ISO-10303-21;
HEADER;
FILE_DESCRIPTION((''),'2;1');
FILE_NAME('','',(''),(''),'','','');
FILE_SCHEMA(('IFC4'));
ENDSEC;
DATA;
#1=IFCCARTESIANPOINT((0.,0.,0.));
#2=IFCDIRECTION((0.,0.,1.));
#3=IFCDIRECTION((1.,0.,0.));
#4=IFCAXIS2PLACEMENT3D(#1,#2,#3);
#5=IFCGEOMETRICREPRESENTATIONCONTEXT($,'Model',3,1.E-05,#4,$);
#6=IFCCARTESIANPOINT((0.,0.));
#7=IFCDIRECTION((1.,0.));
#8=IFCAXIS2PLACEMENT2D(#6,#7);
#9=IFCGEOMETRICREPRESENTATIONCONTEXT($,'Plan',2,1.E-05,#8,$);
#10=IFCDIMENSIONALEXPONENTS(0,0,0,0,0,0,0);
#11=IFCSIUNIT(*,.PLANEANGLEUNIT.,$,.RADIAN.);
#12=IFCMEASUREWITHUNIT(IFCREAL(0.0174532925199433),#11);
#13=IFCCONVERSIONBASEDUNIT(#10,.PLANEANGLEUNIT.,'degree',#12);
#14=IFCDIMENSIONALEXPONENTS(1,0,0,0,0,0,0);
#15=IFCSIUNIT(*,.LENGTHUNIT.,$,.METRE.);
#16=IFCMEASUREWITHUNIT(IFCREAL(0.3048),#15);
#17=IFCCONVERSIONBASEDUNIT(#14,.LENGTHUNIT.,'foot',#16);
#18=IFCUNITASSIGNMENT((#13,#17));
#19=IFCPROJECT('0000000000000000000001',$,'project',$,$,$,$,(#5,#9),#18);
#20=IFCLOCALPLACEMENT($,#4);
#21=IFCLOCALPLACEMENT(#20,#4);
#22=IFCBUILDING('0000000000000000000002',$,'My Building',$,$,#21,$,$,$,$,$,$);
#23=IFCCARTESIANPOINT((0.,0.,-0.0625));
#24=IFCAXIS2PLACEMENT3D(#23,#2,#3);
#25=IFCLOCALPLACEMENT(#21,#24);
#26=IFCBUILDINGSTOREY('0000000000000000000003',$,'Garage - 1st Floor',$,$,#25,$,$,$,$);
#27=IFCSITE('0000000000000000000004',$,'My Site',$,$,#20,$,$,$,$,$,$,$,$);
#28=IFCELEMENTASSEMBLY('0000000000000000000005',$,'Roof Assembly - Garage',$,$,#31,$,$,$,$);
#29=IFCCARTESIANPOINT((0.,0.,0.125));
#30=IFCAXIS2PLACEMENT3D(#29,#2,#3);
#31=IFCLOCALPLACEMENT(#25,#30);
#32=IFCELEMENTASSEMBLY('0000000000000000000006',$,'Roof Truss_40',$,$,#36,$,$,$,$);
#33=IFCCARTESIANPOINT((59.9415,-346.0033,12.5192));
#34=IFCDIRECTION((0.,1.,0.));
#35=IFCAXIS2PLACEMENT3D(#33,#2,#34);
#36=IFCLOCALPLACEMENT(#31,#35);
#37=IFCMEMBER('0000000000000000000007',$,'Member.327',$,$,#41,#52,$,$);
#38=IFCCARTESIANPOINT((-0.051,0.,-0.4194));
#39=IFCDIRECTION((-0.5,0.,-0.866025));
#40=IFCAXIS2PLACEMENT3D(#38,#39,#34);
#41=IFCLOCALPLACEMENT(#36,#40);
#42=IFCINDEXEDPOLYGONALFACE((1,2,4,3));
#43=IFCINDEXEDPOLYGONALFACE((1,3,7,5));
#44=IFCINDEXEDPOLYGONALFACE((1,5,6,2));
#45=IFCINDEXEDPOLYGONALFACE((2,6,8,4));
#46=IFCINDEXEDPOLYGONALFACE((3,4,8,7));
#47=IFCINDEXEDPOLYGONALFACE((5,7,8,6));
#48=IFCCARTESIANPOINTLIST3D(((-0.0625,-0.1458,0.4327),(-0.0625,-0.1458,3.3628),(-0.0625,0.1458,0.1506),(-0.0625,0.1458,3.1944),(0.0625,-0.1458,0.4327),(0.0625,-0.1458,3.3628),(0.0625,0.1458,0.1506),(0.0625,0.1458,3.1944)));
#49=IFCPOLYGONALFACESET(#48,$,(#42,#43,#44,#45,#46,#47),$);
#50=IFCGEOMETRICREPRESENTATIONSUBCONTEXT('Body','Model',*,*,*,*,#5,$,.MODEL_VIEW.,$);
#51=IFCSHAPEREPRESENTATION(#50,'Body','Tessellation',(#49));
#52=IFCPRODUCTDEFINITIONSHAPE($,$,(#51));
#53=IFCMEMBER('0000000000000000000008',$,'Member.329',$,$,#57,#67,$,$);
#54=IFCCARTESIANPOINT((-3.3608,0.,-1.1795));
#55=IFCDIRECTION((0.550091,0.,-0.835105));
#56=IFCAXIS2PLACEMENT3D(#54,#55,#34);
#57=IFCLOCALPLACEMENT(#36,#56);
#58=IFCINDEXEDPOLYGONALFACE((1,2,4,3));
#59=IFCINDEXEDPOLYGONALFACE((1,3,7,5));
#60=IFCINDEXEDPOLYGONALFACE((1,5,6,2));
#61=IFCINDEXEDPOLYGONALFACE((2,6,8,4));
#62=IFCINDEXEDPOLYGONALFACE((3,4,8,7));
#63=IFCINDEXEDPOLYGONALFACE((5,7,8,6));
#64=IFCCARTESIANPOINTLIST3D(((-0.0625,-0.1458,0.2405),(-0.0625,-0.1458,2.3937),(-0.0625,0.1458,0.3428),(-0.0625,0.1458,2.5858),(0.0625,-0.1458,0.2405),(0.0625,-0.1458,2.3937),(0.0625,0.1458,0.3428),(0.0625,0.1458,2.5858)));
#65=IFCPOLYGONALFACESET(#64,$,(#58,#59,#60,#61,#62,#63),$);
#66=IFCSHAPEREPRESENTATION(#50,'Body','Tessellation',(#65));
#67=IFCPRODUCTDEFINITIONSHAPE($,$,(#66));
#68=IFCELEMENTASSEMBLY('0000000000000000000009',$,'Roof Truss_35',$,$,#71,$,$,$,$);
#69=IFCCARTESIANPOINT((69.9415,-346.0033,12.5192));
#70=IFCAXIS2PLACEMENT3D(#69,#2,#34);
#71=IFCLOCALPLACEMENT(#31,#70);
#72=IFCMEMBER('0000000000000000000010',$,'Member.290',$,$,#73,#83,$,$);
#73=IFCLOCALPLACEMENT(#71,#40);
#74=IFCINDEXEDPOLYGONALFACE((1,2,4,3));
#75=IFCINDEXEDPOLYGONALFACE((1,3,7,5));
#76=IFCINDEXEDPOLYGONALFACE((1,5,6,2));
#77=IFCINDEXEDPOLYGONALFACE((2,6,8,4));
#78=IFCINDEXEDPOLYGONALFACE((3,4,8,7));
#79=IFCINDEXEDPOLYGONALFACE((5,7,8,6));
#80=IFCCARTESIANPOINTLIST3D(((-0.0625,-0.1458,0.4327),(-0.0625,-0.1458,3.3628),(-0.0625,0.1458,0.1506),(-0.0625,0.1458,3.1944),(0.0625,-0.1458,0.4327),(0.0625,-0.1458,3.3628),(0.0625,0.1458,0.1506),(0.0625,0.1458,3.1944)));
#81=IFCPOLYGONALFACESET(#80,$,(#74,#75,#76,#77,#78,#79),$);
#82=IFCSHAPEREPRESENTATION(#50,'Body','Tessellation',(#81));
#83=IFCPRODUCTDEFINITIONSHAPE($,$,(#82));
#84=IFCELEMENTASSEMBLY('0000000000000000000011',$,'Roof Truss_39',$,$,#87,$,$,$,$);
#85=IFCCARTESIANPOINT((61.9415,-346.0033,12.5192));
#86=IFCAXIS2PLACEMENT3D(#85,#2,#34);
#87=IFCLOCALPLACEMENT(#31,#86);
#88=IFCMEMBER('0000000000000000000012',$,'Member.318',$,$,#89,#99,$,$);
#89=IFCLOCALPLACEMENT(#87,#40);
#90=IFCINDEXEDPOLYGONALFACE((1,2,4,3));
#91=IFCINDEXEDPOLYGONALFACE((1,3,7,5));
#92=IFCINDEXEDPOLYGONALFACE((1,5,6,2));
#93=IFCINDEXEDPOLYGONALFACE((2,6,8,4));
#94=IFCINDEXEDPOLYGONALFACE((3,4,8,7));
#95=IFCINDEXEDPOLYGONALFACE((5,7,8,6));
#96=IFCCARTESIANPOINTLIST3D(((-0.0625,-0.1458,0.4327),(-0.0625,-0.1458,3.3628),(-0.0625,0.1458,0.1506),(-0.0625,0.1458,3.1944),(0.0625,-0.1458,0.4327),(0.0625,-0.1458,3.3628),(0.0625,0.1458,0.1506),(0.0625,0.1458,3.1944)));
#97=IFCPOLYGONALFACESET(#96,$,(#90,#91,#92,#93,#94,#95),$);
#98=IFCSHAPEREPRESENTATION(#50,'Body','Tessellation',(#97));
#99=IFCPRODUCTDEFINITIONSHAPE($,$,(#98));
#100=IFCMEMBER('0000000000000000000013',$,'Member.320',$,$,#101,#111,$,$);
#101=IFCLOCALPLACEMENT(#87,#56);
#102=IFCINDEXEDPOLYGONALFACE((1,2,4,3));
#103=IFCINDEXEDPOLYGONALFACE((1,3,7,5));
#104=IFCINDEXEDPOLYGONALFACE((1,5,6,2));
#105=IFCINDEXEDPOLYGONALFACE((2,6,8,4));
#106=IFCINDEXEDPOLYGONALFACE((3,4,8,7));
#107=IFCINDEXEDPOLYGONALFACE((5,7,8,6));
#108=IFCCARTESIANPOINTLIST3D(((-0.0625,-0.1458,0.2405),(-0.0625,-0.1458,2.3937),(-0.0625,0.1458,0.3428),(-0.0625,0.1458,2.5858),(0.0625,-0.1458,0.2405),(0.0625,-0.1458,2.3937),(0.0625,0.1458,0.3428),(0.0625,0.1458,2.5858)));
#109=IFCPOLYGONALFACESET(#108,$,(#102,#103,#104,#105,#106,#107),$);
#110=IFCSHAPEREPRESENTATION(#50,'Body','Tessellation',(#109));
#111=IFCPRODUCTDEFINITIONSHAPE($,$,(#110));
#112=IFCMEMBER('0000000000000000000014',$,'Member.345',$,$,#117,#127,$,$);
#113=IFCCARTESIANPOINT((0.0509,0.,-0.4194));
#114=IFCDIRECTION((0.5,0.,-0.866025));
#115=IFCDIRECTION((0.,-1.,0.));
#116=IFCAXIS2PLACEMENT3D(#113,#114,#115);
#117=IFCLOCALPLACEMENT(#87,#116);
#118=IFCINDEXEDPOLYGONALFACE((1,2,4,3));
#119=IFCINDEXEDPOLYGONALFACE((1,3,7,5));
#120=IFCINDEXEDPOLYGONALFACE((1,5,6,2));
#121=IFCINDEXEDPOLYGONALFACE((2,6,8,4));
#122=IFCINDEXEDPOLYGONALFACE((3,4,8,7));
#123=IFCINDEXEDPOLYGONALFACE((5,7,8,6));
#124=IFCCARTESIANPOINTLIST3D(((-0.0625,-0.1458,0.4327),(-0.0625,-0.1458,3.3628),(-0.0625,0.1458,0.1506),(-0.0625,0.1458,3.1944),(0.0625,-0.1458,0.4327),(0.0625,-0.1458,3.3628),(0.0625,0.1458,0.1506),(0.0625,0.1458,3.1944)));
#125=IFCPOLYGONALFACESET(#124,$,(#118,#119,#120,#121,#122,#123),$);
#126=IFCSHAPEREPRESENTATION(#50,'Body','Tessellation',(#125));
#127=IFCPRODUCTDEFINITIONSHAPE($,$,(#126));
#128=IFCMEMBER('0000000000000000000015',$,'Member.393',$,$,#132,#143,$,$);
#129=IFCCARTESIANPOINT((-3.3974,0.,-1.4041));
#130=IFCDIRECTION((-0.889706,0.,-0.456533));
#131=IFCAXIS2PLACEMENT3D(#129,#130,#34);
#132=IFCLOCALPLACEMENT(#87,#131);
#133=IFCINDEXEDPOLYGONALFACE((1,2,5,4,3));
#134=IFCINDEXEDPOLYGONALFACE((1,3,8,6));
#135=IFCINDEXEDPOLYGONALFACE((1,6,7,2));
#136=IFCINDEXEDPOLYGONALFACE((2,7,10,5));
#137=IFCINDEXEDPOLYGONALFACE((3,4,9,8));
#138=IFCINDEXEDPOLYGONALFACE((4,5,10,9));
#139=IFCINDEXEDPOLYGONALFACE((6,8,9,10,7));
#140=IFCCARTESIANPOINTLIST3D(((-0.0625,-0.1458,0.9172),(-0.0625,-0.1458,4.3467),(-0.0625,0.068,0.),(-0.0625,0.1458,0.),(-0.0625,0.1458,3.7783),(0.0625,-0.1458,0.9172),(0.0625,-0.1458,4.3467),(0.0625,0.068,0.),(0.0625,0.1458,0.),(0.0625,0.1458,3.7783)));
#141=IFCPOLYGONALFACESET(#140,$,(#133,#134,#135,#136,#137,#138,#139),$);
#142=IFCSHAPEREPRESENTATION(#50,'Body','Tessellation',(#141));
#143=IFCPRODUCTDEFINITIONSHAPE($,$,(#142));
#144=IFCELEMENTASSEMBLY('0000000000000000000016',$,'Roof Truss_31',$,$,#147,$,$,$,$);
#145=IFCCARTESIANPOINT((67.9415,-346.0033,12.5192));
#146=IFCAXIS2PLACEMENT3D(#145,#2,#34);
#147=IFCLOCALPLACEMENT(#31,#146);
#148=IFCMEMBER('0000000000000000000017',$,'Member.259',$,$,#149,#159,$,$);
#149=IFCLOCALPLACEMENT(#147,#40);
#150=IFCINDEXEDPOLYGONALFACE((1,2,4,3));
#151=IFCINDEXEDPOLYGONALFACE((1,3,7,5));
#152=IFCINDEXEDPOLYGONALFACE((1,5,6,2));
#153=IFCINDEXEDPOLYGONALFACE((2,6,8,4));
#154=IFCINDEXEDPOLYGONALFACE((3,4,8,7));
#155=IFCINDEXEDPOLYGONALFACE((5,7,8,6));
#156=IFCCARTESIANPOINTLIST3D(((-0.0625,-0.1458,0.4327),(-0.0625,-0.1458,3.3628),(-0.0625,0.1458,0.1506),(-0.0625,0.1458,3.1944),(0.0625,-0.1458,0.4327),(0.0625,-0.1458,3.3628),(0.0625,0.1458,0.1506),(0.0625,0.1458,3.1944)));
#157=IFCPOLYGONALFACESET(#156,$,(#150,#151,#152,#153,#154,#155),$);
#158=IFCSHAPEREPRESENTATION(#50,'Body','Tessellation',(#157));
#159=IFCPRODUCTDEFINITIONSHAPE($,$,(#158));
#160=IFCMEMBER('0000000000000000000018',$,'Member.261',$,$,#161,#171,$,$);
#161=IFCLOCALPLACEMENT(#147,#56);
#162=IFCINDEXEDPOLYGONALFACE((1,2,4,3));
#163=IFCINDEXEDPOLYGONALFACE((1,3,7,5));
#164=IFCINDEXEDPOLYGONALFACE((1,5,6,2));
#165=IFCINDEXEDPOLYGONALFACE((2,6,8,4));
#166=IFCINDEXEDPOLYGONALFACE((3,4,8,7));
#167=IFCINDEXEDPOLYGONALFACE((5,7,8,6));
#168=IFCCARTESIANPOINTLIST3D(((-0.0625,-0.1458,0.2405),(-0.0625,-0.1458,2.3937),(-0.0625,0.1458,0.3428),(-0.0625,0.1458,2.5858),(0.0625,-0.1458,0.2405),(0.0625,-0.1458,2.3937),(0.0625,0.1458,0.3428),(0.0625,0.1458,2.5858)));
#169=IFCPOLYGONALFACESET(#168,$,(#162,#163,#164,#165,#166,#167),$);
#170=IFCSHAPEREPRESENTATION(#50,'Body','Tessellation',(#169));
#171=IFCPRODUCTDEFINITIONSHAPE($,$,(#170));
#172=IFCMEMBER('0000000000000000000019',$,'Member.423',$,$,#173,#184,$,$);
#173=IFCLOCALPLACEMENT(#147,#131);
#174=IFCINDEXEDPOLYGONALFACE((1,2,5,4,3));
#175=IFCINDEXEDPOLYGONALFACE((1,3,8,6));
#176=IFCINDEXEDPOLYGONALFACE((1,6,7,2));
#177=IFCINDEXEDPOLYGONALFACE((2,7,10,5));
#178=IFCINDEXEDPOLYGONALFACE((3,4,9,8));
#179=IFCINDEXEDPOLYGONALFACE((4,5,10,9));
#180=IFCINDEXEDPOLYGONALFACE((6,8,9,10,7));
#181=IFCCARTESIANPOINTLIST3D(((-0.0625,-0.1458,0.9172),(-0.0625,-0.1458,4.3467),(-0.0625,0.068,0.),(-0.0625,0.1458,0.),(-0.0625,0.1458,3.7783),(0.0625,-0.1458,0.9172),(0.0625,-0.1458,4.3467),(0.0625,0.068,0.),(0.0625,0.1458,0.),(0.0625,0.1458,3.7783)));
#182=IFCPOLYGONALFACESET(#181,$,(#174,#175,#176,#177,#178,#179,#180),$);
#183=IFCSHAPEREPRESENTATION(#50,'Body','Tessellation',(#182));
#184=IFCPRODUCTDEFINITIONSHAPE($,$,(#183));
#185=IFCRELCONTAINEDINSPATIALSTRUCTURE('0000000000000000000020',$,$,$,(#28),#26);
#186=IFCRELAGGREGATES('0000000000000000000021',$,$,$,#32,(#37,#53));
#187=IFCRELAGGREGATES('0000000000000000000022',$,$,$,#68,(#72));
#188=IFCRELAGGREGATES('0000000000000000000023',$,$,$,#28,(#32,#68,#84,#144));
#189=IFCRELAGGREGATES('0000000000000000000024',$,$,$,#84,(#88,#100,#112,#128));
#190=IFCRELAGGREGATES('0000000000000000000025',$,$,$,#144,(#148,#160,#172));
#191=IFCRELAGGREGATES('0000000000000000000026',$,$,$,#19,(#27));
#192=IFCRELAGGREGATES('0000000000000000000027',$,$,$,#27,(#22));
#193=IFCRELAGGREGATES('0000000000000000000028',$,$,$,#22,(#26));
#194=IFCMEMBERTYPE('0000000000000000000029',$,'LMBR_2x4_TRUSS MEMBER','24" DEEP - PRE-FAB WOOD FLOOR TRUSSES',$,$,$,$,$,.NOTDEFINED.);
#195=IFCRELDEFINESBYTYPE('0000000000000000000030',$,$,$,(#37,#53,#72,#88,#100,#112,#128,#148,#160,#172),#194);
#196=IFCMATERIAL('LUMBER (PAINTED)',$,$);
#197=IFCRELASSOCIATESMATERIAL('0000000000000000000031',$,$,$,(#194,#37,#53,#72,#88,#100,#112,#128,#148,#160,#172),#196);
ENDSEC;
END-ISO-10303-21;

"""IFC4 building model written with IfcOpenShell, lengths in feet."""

from ifc_helpers import new_model, entity, si_unit, converted_unit, frame, origin_with_axes, origin_2d_with_axis, place, context, subcontext, project, spatial, indexed_curve, outline, extrude, clip, halfspace, material, material_profile, profile_set, profile_usage, type_object, element, aggregate, save


model = new_model("IFC4")

# Units and contexts
model_context = context("Model", 3, precision=1e-05, world=origin_with_axes())
plan_context = context("Plan", 2, precision=1e-05, world=origin_2d_with_axis())
body_context = subcontext(model_context, "Body", "Model", "MODEL_VIEW")
ifc_project = project(units=[converted_unit("PLANEANGLEUNIT", "degree", entity("IfcReal", 0.0174532925199433), si_unit("PLANEANGLEUNIT", "RADIAN"), dimensions=[0, 0, 0, 0, 0, 0, 0]), converted_unit("LENGTHUNIT", "foot", entity("IfcReal", 0.3048), si_unit("LENGTHUNIT", "METRE"), dimensions=[1, 0, 0, 0, 0, 0, 0])], contexts=[model_context, plan_context])

# Site, building, storey
site_placement = place(None, origin_with_axes())
site = spatial("IfcSite", under=ifc_project, at=site_placement, Name="My Site")
building_placement = place(site_placement, origin_with_axes())
building = spatial("IfcBuilding", under=site, at=building_placement, Name="My Building")
storey_placement = place(building_placement, frame((0.0, 0.0, -0.0625), z_axis=(0.0, 0.0, 1.0), x_axis=(1.0, 0.0, 0.0)))
storey = spatial("IfcBuildingStorey", under=building, at=storey_placement, Name="Garage - 1st Floor")

# Element assemblies, members
assembly_1_placement = place(storey_placement, frame((0.0, 0.0, 0.125), z_axis=(0.0, 0.0, 1.0), x_axis=(1.0, 0.0, 0.0)))
assembly_1 = element("IfcElementAssembly", 1, at=assembly_1_placement, inside=storey, Name="Roof Assembly - Garage")
assembly_2_placement = place(assembly_1_placement, frame((59.9415, -346.0033, 12.5192), z_axis=(0.0, 0.0, 1.0), x_axis=(0.0, 1.0, 0.0)))
assembly_2 = element("IfcElementAssembly", 2, at=assembly_2_placement, Name="Roof Truss_40")
ifc_material = material(Name="LUMBER (PAINTED)")
ifc_material_profile_1 = material_profile(ifc_material, outline(indexed_curve([(-0.0625, -0.1458), (0.0625, -0.1458), (0.0625, 0.1458), (-0.0625, 0.1458), (-0.0625, -0.1458)])))
ifc_profile_set_1 = profile_set([ifc_material_profile_1])
ifc_profile_usage_1 = profile_usage(ifc_profile_set_1)
member_type_1 = type_object("IfcMemberType", Name="LMBR_2x4_TRUSS MEMBER", Description="24\" DEEP - PRE-FAB WOOD FLOOR TRUSSES", PredefinedType="NOTDEFINED", material=ifc_profile_set_1)
member_1_placement = place(assembly_2_placement, frame((-0.051, 0.0, -0.4194), z_axis=(-0.5, 0.0, -0.866025), x_axis=(0.0, 1.0, 0.0)))
member_1 = element("IfcMember", 3, at=member_1_placement, type_object=member_type_1, material=ifc_profile_usage_1, Name="Member.327", context=body_context, shape_type="Clipping", body=[
    clip(clip(extrude(outline(indexed_curve([(-0.0625, -0.1458), (0.0625, -0.1458), (0.0625, 0.1458), (-0.0625, 0.1458), (-0.0625, -0.1458)])), origin_with_axes(), (0.0, 0.0, 1.0), 3.5703), halfspace(frame((0.0, 0.2544, 0.0456), z_axis=(0.0, -0.69516, -0.718855), x_axis=(-1.0, 0.000001, 0.0)), False)), halfspace(frame((0.0, 7.9951, -1.3373), z_axis=(0.0, 0.5, 0.866026), x_axis=(1.0, 0.0, 0.0)), False)),
])
ifc_profile_usage_2 = profile_usage(ifc_profile_set_1)
member_2_placement = place(assembly_2_placement, frame((-3.3608, 0.0, -1.1795), z_axis=(0.550091, 0.0, -0.835105), x_axis=(0.0, 1.0, 0.0)))
member_2 = element("IfcMember", 4, at=member_2_placement, type_object=member_type_1, material=ifc_profile_usage_2, Name="Member.329", context=body_context, shape_type="Clipping", body=[
    clip(clip(extrude(outline(indexed_curve([(-0.0625, -0.1458), (0.0625, -0.1458), (0.0625, 0.1458), (-0.0625, 0.1458), (-0.0625, -0.1458)])), origin_with_axes(), (0.0, 0.0, 1.0), 2.7815), halfspace(frame((0.0, 3.2555, 1.4338), z_axis=(0.0, 0.331063, -0.943609), x_axis=(1.0, 0.0, 0.0)), False)), halfspace(frame((0.0, 7.9609, 7.7337), z_axis=(0.0, -0.550091, 0.835105), x_axis=(-1.0, 0.0, 0.0)), False)),
])
aggregate(assembly_2, [member_1, member_2])
assembly_3_placement = place(assembly_1_placement, frame((69.9415, -346.0033, 12.5192), z_axis=(0.0, 0.0, 1.0), x_axis=(0.0, 1.0, 0.0)))
assembly_3 = element("IfcElementAssembly", 5, at=assembly_3_placement, Name="Roof Truss_35")
ifc_profile_usage_3 = profile_usage(ifc_profile_set_1)
member_3_placement = place(assembly_3_placement, frame((-0.051, 0.0, -0.4194), z_axis=(-0.5, 0.0, -0.866025), x_axis=(0.0, 1.0, 0.0)))
member_3 = element("IfcMember", 6, at=member_3_placement, type_object=member_type_1, material=ifc_profile_usage_3, Name="Member.290", context=body_context, shape_type="Clipping", body=[
    clip(clip(extrude(outline(indexed_curve([(-0.0625, -0.1458), (0.0625, -0.1458), (0.0625, 0.1458), (-0.0625, 0.1458), (-0.0625, -0.1458)])), origin_with_axes(), (0.0, 0.0, 1.0), 3.5703), halfspace(frame((0.0, 0.2544, 0.0456), z_axis=(0.0, -0.69516, -0.718855), x_axis=(-1.0, 0.000001, 0.0)), False)), halfspace(frame((0.0, 7.9951, -1.3373), z_axis=(0.0, 0.5, 0.866026), x_axis=(1.0, 0.0, 0.0)), False)),
])
aggregate(assembly_3, [member_3])
assembly_4_placement = place(assembly_1_placement, frame((61.9415, -346.0033, 12.5192), z_axis=(0.0, 0.0, 1.0), x_axis=(0.0, 1.0, 0.0)))
assembly_4 = element("IfcElementAssembly", 7, at=assembly_4_placement, Name="Roof Truss_39")
ifc_profile_usage_4 = profile_usage(ifc_profile_set_1)
member_4_placement = place(assembly_4_placement, frame((-0.051, 0.0, -0.4194), z_axis=(-0.5, 0.0, -0.866025), x_axis=(0.0, 1.0, 0.0)))
member_4 = element("IfcMember", 8, at=member_4_placement, type_object=member_type_1, material=ifc_profile_usage_4, Name="Member.318", context=body_context, shape_type="Clipping", body=[
    clip(clip(extrude(outline(indexed_curve([(-0.0625, -0.1458), (0.0625, -0.1458), (0.0625, 0.1458), (-0.0625, 0.1458), (-0.0625, -0.1458)])), origin_with_axes(), (0.0, 0.0, 1.0), 3.5703), halfspace(frame((0.0, 0.2544, 0.0456), z_axis=(0.0, -0.69516, -0.718855), x_axis=(-1.0, 0.000001, 0.0)), False)), halfspace(frame((0.0, 7.9951, -1.3373), z_axis=(0.0, 0.5, 0.866026), x_axis=(1.0, 0.0, 0.0)), False)),
])
ifc_profile_usage_5 = profile_usage(ifc_profile_set_1)
member_5_placement = place(assembly_4_placement, frame((-3.3608, 0.0, -1.1795), z_axis=(0.550091, 0.0, -0.835105), x_axis=(0.0, 1.0, 0.0)))
member_5 = element("IfcMember", 9, at=member_5_placement, type_object=member_type_1, material=ifc_profile_usage_5, Name="Member.320", context=body_context, shape_type="Clipping", body=[
    clip(clip(extrude(outline(indexed_curve([(-0.0625, -0.1458), (0.0625, -0.1458), (0.0625, 0.1458), (-0.0625, 0.1458), (-0.0625, -0.1458)])), origin_with_axes(), (0.0, 0.0, 1.0), 2.7815), halfspace(frame((0.0, 3.2555, 1.4338), z_axis=(0.0, 0.331063, -0.943609), x_axis=(1.0, 0.0, 0.0)), False)), halfspace(frame((0.0, 7.9609, 7.7337), z_axis=(0.0, -0.550091, 0.835105), x_axis=(-1.0, 0.0, 0.0)), False)),
])
ifc_profile_usage_6 = profile_usage(ifc_profile_set_1)
member_6_placement = place(assembly_4_placement, frame((0.0509, 0.0, -0.4194), z_axis=(0.5, 0.0, -0.866025), x_axis=(0.0, -1.0, 0.0)))
member_6 = element("IfcMember", 10, at=member_6_placement, type_object=member_type_1, material=ifc_profile_usage_6, Name="Member.345", context=body_context, shape_type="Clipping", body=[
    clip(clip(extrude(outline(indexed_curve([(-0.0625, -0.1458), (0.0625, -0.1458), (0.0625, 0.1458), (-0.0625, 0.1458), (-0.0625, -0.1458)])), origin_with_axes(), (0.0, 0.0, 1.0), 3.5703), halfspace(frame((0.0, -5.0674, 6.2043), z_axis=(0.0, 0.5, 0.866025), x_axis=(1.0, 0.0, 0.0)), False)), halfspace(frame((0.0, 0.2544, 0.0456), z_axis=(0.0, -0.695161, -0.718855), x_axis=(-1.0, 0.0, 0.0)), False)),
])
ifc_profile_usage_7 = profile_usage(ifc_profile_set_1)
member_7_placement = place(assembly_4_placement, frame((-3.3974, 0.0, -1.4041), z_axis=(-0.889706, 0.0, -0.456533), x_axis=(0.0, 1.0, 0.0)))
member_7 = element("IfcMember", 11, at=member_7_placement, type_object=member_type_1, material=ifc_profile_usage_7, Name="Member.393", context=body_context, shape_type="Clipping", body=[
    clip(clip(extrude(outline(indexed_curve([(-0.0625, -0.1458), (0.0625, -0.1458), (0.0625, 0.1458), (-0.0625, 0.1458), (-0.0625, -0.1458)])), origin_with_axes(), (0.0, 0.0, 1.0), 4.3542), halfspace(frame((0.0, 6.6441, -8.8858), z_axis=(0.0, 0.889707, 0.456533), x_axis=(1.0, 0.0, 0.0)), False)), halfspace(frame((0.0, 0.8902, -3.5265), z_axis=(-0.000001, -0.973882, -0.227053), x_axis=(-1.0, 0.000001, 0.0)), False)),
])
assembly_5_placement = place(assembly_1_placement, frame((67.9415, -346.0033, 12.5192), z_axis=(0.0, 0.0, 1.0), x_axis=(0.0, 1.0, 0.0)))
assembly_5 = element("IfcElementAssembly", 12, at=assembly_5_placement, Name="Roof Truss_31")
ifc_profile_usage_8 = profile_usage(ifc_profile_set_1)
member_8_placement = place(assembly_5_placement, frame((-0.051, 0.0, -0.4194), z_axis=(-0.5, 0.0, -0.866025), x_axis=(0.0, 1.0, 0.0)))
member_8 = element("IfcMember", 13, at=member_8_placement, type_object=member_type_1, material=ifc_profile_usage_8, Name="Member.259", context=body_context, shape_type="Clipping", body=[
    clip(clip(extrude(outline(indexed_curve([(-0.0625, -0.1458), (0.0625, -0.1458), (0.0625, 0.1458), (-0.0625, 0.1458), (-0.0625, -0.1458)])), origin_with_axes(), (0.0, 0.0, 1.0), 3.5703), halfspace(frame((0.0, 0.2544, 0.0456), z_axis=(0.0, -0.69516, -0.718855), x_axis=(-1.0, 0.000001, 0.0)), False)), halfspace(frame((0.0, 7.9951, -1.3373), z_axis=(0.0, 0.5, 0.866026), x_axis=(1.0, 0.0, 0.0)), False)),
])
ifc_profile_usage_9 = profile_usage(ifc_profile_set_1)
member_9_placement = place(assembly_5_placement, frame((-3.3608, 0.0, -1.1795), z_axis=(0.550091, 0.0, -0.835105), x_axis=(0.0, 1.0, 0.0)))
member_9 = element("IfcMember", 14, at=member_9_placement, type_object=member_type_1, material=ifc_profile_usage_9, Name="Member.261", context=body_context, shape_type="Clipping", body=[
    clip(clip(extrude(outline(indexed_curve([(-0.0625, -0.1458), (0.0625, -0.1458), (0.0625, 0.1458), (-0.0625, 0.1458), (-0.0625, -0.1458)])), origin_with_axes(), (0.0, 0.0, 1.0), 2.7815), halfspace(frame((0.0, 3.2555, 1.4338), z_axis=(0.0, 0.331063, -0.943609), x_axis=(1.0, 0.0, 0.0)), False)), halfspace(frame((0.0, 7.9609, 7.7337), z_axis=(0.0, -0.550091, 0.835105), x_axis=(-1.0, 0.0, 0.0)), False)),
])
ifc_profile_usage_10 = profile_usage(ifc_profile_set_1)
member_10_placement = place(assembly_5_placement, frame((-3.3974, 0.0, -1.4041), z_axis=(-0.889706, 0.0, -0.456533), x_axis=(0.0, 1.0, 0.0)))
member_10 = element("IfcMember", 15, at=member_10_placement, type_object=member_type_1, material=ifc_profile_usage_10, Name="Member.423", context=body_context, shape_type="Clipping", body=[
    clip(clip(extrude(outline(indexed_curve([(-0.0625, -0.1458), (0.0625, -0.1458), (0.0625, 0.1458), (-0.0625, 0.1458), (-0.0625, -0.1458)])), origin_with_axes(), (0.0, 0.0, 1.0), 4.3542), halfspace(frame((0.0, 6.6441, -8.8858), z_axis=(0.0, 0.889707, 0.456533), x_axis=(1.0, 0.0, 0.0)), False)), halfspace(frame((0.0, 0.8902, -3.5265), z_axis=(-0.000001, -0.973882, -0.227053), x_axis=(-1.0, 0.000001, 0.0)), False)),
])
aggregate(assembly_1, [assembly_2, assembly_3, assembly_4, assembly_5])
aggregate(assembly_4, [member_4, member_5, member_6, member_7])
aggregate(assembly_5, [member_8, member_9, member_10])

save(model, "model.ifc")
